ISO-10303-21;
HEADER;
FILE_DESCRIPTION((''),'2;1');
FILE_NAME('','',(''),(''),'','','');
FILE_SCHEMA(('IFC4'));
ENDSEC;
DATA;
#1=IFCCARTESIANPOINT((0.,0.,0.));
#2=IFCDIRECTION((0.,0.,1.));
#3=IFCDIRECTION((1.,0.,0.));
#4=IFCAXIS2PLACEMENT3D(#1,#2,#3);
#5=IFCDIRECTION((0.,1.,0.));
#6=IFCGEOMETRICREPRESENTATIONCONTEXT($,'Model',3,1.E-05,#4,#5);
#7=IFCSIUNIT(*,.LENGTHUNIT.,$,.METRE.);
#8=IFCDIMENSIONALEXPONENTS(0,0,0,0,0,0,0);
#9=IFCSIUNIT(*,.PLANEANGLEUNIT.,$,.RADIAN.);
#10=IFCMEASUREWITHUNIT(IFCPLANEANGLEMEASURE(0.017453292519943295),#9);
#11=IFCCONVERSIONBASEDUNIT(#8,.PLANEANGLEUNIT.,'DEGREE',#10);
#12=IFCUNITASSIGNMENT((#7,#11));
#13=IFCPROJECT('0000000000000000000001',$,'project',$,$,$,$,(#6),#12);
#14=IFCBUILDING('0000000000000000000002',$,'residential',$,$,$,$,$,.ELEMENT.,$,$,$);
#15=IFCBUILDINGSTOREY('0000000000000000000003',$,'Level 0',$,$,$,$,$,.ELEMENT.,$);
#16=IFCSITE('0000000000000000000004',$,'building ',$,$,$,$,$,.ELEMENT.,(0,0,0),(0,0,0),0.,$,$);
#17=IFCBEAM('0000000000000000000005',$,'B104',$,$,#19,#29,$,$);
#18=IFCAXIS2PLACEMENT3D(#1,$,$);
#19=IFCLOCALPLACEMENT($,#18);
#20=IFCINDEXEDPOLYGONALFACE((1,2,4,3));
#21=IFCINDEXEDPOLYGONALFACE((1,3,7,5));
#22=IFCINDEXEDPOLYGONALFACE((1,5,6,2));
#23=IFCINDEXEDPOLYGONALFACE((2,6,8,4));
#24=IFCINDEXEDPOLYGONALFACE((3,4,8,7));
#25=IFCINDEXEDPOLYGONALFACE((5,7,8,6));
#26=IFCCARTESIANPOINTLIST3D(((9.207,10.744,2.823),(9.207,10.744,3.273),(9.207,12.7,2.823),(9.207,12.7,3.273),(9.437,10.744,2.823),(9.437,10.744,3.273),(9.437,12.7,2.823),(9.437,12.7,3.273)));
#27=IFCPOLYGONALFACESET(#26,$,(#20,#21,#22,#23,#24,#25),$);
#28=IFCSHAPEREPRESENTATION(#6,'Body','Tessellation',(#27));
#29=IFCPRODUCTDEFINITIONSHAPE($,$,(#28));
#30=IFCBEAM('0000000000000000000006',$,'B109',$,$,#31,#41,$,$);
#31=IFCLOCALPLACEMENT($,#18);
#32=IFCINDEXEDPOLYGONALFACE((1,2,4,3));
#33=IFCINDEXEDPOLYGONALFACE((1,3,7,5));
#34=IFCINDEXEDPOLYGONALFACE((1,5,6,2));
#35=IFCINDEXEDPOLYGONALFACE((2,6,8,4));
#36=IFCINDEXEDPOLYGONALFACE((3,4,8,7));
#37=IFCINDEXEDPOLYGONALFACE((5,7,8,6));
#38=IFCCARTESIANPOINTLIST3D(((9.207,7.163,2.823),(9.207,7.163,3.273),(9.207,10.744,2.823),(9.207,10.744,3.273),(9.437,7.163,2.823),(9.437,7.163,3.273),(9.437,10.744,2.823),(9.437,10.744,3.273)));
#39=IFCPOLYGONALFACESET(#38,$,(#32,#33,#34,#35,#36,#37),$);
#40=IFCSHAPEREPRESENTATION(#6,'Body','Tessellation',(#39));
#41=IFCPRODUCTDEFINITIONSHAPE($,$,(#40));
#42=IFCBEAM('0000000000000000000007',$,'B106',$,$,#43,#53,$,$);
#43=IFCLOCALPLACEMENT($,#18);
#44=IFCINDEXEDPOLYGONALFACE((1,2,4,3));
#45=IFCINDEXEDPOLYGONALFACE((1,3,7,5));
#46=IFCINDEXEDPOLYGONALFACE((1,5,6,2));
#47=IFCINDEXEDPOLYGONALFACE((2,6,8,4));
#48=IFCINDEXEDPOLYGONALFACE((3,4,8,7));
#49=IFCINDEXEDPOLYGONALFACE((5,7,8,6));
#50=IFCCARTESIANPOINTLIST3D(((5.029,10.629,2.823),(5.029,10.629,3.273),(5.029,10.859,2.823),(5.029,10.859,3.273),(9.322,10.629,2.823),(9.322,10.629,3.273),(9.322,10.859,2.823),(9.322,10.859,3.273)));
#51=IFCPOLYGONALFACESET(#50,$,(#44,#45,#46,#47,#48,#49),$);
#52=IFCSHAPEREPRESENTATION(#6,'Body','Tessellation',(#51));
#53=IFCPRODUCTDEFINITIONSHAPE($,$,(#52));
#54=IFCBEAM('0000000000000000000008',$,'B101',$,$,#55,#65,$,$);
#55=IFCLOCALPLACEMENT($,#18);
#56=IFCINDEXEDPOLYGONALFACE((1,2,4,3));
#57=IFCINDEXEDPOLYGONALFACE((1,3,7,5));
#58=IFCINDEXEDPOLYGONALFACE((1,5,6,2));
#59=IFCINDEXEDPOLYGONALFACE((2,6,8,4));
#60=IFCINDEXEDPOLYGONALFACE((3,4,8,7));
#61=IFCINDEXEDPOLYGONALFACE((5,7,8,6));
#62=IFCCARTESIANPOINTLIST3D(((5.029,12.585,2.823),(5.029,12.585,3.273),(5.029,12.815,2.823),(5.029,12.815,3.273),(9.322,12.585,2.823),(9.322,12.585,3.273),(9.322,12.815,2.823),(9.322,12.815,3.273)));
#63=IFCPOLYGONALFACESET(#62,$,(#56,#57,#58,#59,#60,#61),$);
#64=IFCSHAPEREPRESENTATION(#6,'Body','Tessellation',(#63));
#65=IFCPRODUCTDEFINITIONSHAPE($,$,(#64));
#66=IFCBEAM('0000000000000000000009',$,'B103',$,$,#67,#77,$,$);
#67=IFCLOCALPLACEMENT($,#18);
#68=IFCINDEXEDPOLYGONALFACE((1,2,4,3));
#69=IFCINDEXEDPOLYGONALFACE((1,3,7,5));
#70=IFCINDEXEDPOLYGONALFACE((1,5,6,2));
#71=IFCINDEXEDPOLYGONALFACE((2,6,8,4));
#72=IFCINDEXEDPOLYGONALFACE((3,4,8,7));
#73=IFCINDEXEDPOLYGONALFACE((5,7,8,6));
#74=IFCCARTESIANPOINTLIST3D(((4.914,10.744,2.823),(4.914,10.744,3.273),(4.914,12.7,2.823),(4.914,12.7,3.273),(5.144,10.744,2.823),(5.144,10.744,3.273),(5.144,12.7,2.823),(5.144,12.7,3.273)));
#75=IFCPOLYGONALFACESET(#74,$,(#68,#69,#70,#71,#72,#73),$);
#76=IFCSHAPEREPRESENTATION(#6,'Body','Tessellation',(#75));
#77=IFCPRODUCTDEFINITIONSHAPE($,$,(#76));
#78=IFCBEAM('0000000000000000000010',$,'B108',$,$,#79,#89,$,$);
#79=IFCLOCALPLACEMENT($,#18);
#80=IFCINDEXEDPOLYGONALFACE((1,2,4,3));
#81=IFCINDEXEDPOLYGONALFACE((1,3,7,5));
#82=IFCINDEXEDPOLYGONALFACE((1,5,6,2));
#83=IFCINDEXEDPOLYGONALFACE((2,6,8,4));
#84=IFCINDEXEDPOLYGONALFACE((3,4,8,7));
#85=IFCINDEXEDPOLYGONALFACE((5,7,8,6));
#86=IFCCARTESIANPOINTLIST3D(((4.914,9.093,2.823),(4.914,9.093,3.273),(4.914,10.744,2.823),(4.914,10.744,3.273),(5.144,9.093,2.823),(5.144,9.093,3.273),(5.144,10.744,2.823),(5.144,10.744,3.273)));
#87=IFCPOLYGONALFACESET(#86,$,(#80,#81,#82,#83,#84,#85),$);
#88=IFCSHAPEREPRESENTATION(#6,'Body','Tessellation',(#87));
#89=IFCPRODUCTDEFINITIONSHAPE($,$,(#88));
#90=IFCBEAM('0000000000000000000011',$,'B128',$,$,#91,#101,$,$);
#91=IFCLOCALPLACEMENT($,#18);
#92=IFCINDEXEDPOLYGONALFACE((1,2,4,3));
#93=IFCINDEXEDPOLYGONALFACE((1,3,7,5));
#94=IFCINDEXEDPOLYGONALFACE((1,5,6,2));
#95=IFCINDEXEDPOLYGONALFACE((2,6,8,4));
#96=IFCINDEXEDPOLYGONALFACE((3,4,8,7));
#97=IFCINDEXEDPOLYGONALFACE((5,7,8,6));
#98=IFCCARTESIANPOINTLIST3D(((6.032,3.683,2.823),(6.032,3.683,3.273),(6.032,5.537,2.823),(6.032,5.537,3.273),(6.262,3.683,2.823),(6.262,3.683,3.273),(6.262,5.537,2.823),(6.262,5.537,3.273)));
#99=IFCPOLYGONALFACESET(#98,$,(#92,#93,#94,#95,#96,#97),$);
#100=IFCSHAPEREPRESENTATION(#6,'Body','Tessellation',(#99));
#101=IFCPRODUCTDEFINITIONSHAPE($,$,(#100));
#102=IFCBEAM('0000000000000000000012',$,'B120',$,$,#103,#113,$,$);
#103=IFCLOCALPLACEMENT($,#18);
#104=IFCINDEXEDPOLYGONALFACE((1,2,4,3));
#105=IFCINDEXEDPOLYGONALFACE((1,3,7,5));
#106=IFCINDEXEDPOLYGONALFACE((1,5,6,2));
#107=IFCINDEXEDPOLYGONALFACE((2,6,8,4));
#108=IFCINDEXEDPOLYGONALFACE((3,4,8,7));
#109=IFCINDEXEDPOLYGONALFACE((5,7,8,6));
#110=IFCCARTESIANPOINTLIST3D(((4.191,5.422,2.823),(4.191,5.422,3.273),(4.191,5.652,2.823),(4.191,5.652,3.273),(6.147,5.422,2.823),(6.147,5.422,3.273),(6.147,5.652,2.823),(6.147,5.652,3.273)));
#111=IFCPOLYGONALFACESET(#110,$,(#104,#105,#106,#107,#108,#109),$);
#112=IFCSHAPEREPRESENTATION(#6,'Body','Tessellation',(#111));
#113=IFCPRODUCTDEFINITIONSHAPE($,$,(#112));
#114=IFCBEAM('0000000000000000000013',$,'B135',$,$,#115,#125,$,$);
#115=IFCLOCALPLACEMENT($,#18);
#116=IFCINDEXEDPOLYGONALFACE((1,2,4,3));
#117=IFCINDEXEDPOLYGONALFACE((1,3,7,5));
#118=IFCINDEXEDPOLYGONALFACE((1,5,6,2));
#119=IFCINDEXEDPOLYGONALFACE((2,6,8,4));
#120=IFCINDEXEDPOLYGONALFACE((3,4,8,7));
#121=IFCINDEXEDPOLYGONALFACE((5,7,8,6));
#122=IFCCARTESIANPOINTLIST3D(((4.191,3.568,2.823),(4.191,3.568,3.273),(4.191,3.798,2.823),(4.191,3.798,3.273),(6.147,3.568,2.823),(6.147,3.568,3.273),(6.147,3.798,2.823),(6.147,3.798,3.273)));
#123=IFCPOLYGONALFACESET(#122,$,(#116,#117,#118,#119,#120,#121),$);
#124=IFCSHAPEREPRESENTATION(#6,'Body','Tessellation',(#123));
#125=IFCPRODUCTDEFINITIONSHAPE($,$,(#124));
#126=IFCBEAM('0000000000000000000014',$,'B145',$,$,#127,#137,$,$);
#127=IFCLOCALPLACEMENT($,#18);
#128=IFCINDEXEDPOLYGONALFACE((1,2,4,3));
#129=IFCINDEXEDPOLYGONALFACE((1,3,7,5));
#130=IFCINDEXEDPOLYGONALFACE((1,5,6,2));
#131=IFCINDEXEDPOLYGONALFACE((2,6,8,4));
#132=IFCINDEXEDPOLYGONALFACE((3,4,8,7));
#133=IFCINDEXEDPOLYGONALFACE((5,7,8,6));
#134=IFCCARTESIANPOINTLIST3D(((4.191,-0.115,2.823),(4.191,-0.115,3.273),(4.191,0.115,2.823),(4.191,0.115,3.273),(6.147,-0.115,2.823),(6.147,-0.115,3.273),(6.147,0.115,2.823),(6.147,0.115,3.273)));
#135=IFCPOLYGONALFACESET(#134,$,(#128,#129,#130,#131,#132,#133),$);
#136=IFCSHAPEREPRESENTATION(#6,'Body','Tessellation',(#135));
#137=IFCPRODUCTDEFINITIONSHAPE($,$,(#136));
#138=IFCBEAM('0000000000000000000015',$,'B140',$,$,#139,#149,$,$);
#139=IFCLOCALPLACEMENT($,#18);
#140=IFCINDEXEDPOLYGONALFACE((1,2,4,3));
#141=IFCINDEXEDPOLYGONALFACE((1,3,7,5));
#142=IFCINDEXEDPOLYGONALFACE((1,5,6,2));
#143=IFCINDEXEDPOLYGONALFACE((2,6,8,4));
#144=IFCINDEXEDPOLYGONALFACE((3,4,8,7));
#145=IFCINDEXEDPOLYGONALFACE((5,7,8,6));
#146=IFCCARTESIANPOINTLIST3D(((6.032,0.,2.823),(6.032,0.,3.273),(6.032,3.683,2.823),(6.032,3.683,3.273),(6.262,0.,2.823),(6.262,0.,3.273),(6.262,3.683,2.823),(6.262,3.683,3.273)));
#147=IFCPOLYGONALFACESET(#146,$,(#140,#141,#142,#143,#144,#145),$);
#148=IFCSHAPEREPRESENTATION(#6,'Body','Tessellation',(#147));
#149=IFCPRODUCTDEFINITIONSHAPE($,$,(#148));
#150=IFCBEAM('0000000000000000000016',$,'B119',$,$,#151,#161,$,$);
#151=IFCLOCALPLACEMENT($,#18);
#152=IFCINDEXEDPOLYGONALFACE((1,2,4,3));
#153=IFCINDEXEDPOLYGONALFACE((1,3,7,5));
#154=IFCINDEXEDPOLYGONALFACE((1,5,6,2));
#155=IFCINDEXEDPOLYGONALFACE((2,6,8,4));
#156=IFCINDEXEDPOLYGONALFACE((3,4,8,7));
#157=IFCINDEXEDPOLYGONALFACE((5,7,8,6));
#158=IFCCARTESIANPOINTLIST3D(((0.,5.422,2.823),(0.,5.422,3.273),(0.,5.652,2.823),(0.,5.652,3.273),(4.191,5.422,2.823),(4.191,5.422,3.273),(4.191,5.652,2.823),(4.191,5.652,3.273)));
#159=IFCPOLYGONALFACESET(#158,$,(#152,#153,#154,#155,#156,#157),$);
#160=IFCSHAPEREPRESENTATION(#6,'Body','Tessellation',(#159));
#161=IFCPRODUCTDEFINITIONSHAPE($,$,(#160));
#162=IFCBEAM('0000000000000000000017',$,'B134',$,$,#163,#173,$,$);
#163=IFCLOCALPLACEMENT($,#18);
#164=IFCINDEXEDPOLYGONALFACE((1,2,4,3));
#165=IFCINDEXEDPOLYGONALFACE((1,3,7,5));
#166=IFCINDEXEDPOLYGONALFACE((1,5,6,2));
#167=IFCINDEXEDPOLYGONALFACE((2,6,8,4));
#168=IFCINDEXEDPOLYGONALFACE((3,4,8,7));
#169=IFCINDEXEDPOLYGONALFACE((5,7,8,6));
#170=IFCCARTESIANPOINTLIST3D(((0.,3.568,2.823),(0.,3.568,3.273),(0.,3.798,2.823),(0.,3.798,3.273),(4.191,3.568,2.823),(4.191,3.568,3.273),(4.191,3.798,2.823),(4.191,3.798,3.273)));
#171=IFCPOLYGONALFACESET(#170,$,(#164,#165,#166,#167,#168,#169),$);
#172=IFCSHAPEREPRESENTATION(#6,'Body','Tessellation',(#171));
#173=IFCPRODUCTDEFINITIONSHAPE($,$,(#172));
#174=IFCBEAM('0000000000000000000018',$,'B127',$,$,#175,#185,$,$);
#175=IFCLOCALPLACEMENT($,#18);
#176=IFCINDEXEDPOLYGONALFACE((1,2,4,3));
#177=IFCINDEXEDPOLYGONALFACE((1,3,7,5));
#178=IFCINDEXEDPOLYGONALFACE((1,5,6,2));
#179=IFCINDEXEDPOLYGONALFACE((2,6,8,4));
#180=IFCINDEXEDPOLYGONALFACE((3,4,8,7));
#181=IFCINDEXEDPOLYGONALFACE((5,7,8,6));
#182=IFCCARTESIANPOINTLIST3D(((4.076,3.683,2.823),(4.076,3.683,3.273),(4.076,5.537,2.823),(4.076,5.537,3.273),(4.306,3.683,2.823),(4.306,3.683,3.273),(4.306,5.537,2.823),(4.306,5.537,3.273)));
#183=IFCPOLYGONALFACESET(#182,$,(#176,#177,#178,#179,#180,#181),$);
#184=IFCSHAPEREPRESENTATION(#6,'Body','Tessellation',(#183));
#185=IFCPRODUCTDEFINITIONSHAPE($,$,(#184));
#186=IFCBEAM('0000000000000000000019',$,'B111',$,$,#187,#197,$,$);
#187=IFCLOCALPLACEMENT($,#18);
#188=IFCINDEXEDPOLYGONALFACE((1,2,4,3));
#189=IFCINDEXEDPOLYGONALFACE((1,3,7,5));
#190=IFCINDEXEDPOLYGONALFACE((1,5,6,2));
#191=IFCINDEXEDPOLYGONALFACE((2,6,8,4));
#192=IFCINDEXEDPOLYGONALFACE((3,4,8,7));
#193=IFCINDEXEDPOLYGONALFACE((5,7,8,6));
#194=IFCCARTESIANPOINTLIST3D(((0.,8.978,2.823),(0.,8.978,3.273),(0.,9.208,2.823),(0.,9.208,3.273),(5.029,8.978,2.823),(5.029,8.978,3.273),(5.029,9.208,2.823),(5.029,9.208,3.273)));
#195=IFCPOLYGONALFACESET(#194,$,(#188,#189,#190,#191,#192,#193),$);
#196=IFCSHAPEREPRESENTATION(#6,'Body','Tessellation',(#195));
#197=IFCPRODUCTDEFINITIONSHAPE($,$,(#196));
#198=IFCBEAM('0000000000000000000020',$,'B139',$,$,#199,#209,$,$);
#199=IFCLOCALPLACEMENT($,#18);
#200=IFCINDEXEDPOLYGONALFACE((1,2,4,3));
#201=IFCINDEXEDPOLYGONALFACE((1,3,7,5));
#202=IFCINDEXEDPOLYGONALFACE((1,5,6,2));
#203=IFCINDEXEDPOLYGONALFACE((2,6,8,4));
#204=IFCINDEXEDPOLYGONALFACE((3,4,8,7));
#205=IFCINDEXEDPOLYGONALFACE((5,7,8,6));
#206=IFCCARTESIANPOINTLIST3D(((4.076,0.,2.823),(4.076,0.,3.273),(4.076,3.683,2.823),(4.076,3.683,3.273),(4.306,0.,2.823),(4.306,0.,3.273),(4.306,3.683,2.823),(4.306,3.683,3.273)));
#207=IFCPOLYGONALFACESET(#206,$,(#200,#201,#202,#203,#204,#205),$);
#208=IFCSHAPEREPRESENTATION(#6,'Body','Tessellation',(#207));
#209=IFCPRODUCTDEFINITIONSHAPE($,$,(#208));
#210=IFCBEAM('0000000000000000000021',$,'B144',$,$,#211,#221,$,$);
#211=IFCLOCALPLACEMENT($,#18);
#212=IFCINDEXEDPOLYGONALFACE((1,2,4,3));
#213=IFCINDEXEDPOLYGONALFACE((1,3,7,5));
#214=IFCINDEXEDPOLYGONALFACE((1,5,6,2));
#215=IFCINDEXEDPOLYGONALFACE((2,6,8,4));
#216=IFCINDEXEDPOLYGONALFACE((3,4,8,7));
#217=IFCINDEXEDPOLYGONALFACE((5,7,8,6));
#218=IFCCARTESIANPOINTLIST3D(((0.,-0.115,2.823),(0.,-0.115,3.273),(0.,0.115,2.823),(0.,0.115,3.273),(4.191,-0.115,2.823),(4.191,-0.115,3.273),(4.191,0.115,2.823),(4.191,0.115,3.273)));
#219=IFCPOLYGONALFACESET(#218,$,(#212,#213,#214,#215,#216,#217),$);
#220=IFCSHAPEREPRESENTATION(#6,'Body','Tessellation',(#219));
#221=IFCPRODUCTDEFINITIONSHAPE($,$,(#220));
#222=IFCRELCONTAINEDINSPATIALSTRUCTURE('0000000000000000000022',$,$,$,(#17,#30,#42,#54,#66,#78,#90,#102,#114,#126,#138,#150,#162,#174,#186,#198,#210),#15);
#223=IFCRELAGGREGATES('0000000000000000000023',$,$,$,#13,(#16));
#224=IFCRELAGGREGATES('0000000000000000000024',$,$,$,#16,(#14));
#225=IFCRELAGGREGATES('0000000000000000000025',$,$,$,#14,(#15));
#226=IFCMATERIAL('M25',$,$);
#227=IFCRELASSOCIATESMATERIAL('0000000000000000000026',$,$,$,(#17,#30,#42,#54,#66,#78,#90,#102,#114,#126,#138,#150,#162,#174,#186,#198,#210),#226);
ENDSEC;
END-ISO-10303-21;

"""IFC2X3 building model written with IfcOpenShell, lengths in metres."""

from ifc_helpers import new_model, entity, si_unit, converted_unit, direction, frame, frame_2d, origin_with_axes, place, context, project, spatial, rectangle, extrude, material, element, save


model = new_model("IFC2X3")

# Units and contexts
model_context = context("Model", 3, precision=1e-05, world=origin_with_axes(), true_north=direction((0.0, 1.0, 0.0)))
ifc_project = project(units=[si_unit("LENGTHUNIT", "METRE"), converted_unit("PLANEANGLEUNIT", "DEGREE", entity("IfcPlaneAngleMeasure", 0.017453292519943295), si_unit("PLANEANGLEUNIT", "RADIAN"), dimensions=[0, 0, 0, 0, 0, 0, 0])], contexts=[model_context])

# Site, building, storey
site = spatial("IfcSite", under=ifc_project, Name="building ", CompositionType="ELEMENT", RefLatitude=(0, 0, 0), RefLongitude=(0, 0, 0), RefElevation=0.0)
building = spatial("IfcBuilding", under=site, Name="residential", CompositionType="ELEMENT")
storey = spatial("IfcBuildingStorey", under=building, Name="Level 0", CompositionType="ELEMENT")

# Beams
ifc_material = material(Name="M25")
placement = place(None, origin_with_axes())
element("IfcBeam", 1, at=placement, inside=storey, material=ifc_material, Name="B104", context=model_context, shape_type="SweptSolid", body=[
    extrude(rectangle(XDim=0.23, YDim=0.45, at=frame_2d((0.0, 0.0), x_axis=(0.0, 1.0, 0.0))), frame((9.322, 10.744, 3.048), z_axis=(0.0, 1.0, 0.0), x_axis=(0.0, 0.0, -1.0)), (0.0, 0.0, 1.0), 1.956),
])
element("IfcBeam", 2, at=placement, inside=storey, material=ifc_material, Name="B109", context=model_context, shape_type="SweptSolid", body=[
    extrude(rectangle(XDim=0.23, YDim=0.45, at=frame_2d((0.0, 0.0), x_axis=(0.0, 1.0, 0.0))), frame((9.322, 7.163, 3.048), z_axis=(0.0, 1.0, 0.0), x_axis=(0.0, 0.0, -1.0)), (0.0, 0.0, 1.0), 3.581),
])
element("IfcBeam", 3, at=placement, inside=storey, material=ifc_material, Name="B106", context=model_context, shape_type="SweptSolid", body=[
    extrude(rectangle(XDim=0.23, YDim=0.45, at=frame_2d((0.0, 0.0), x_axis=(0.0, 1.0, 0.0))), frame((5.029, 10.744, 3.048), z_axis=(1.0, 0.0, 0.0), x_axis=(0.0, 0.0, -1.0)), (0.0, 0.0, 1.0), 4.293),
])
element("IfcBeam", 4, at=placement, inside=storey, material=ifc_material, Name="B101", context=model_context, shape_type="SweptSolid", body=[
    extrude(rectangle(XDim=0.23, YDim=0.45, at=frame_2d((0.0, 0.0), x_axis=(0.0, 1.0, 0.0))), frame((5.029, 12.7, 3.048), z_axis=(1.0, 0.0, 0.0), x_axis=(0.0, 0.0, -1.0)), (0.0, 0.0, 1.0), 4.293),
])
element("IfcBeam", 5, at=placement, inside=storey, material=ifc_material, Name="B103", context=model_context, shape_type="SweptSolid", body=[
    extrude(rectangle(XDim=0.23, YDim=0.45, at=frame_2d((0.0, 0.0), x_axis=(0.0, 1.0, 0.0))), frame((5.029, 10.744, 3.048), z_axis=(0.0, 1.0, 0.0), x_axis=(0.0, 0.0, -1.0)), (0.0, 0.0, 1.0), 1.956),
])
element("IfcBeam", 6, at=placement, inside=storey, material=ifc_material, Name="B108", context=model_context, shape_type="SweptSolid", body=[
    extrude(rectangle(XDim=0.23, YDim=0.45, at=frame_2d((0.0, 0.0), x_axis=(0.0, 1.0, 0.0))), frame((5.029, 9.093, 3.048), z_axis=(0.0, 1.0, 0.0), x_axis=(0.0, 0.0, -1.0)), (0.0, 0.0, 1.0), 1.651),
])
element("IfcBeam", 7, at=placement, inside=storey, material=ifc_material, Name="B128", context=model_context, shape_type="SweptSolid", body=[
    extrude(rectangle(XDim=0.23, YDim=0.45, at=frame_2d((0.0, 0.0), x_axis=(0.0, 1.0, 0.0))), frame((6.147, 3.683, 3.048), z_axis=(0.0, 1.0, 0.0), x_axis=(0.0, 0.0, -1.0)), (0.0, 0.0, 1.0), 1.854),
])
element("IfcBeam", 8, at=placement, inside=storey, material=ifc_material, Name="B120", context=model_context, shape_type="SweptSolid", body=[
    extrude(rectangle(XDim=0.23, YDim=0.45, at=frame_2d((0.0, 0.0), x_axis=(0.0, 1.0, 0.0))), frame((4.191, 5.537, 3.048), z_axis=(1.0, 0.0, 0.0), x_axis=(0.0, 0.0, -1.0)), (0.0, 0.0, 1.0), 1.956),
])
element("IfcBeam", 9, at=placement, inside=storey, material=ifc_material, Name="B135", context=model_context, shape_type="SweptSolid", body=[
    extrude(rectangle(XDim=0.23, YDim=0.45, at=frame_2d((0.0, 0.0), x_axis=(0.0, 1.0, 0.0))), frame((4.191, 3.683, 3.048), z_axis=(1.0, 0.0, 0.0), x_axis=(0.0, 0.0, -1.0)), (0.0, 0.0, 1.0), 1.956),
])
element("IfcBeam", 10, at=placement, inside=storey, material=ifc_material, Name="B145", context=model_context, shape_type="SweptSolid", body=[
    extrude(rectangle(XDim=0.23, YDim=0.45, at=frame_2d((0.0, 0.0), x_axis=(0.0, 1.0, 0.0))), frame((4.191, 0.0, 3.048), z_axis=(1.0, 0.0, 0.0), x_axis=(0.0, 0.0, -1.0)), (0.0, 0.0, 1.0), 1.956),
])
element("IfcBeam", 11, at=placement, inside=storey, material=ifc_material, Name="B140", context=model_context, shape_type="SweptSolid", body=[
    extrude(rectangle(XDim=0.23, YDim=0.45, at=frame_2d((0.0, 0.0), x_axis=(0.0, 1.0, 0.0))), frame((6.147, 0.0, 3.048), z_axis=(0.0, 1.0, 0.0), x_axis=(0.0, 0.0, -1.0)), (0.0, 0.0, 1.0), 3.683),
])
element("IfcBeam", 12, at=placement, inside=storey, material=ifc_material, Name="B119", context=model_context, shape_type="SweptSolid", body=[
    extrude(rectangle(XDim=0.23, YDim=0.45, at=frame_2d((0.0, 0.0), x_axis=(0.0, 1.0, 0.0))), frame((0.0, 5.537, 3.048), z_axis=(1.0, 0.0, 0.0), x_axis=(0.0, 0.0, -1.0)), (0.0, 0.0, 1.0), 4.191),
])
element("IfcBeam", 13, at=placement, inside=storey, material=ifc_material, Name="B134", context=model_context, shape_type="SweptSolid", body=[
    extrude(rectangle(XDim=0.23, YDim=0.45, at=frame_2d((0.0, 0.0), x_axis=(0.0, 1.0, 0.0))), frame((0.0, 3.683, 3.048), z_axis=(1.0, 0.0, 0.0), x_axis=(0.0, 0.0, -1.0)), (0.0, 0.0, 1.0), 4.191),
])
element("IfcBeam", 14, at=placement, inside=storey, material=ifc_material, Name="B127", context=model_context, shape_type="SweptSolid", body=[
    extrude(rectangle(XDim=0.23, YDim=0.45, at=frame_2d((0.0, 0.0), x_axis=(0.0, 1.0, 0.0))), frame((4.191, 3.683, 3.048), z_axis=(0.0, 1.0, 0.0), x_axis=(0.0, 0.0, -1.0)), (0.0, 0.0, 1.0), 1.854),
])
element("IfcBeam", 15, at=placement, inside=storey, material=ifc_material, Name="B111", context=model_context, shape_type="SweptSolid", body=[
    extrude(rectangle(XDim=0.23, YDim=0.45, at=frame_2d((0.0, 0.0), x_axis=(0.0, 1.0, 0.0))), frame((0.0, 9.093, 3.048), z_axis=(1.0, 0.0, 0.0), x_axis=(0.0, 0.0, -1.0)), (0.0, 0.0, 1.0), 5.029),
])
element("IfcBeam", 16, at=placement, inside=storey, material=ifc_material, Name="B139", context=model_context, shape_type="SweptSolid", body=[
    extrude(rectangle(XDim=0.23, YDim=0.45, at=frame_2d((0.0, 0.0), x_axis=(0.0, 1.0, 0.0))), frame((4.191, 0.0, 3.048), z_axis=(0.0, 1.0, 0.0), x_axis=(0.0, 0.0, -1.0)), (0.0, 0.0, 1.0), 3.683),
])
element("IfcBeam", 17, at=placement, inside=storey, material=ifc_material, Name="B144", context=model_context, shape_type="SweptSolid", body=[
    extrude(rectangle(XDim=0.23, YDim=0.45, at=frame_2d((0.0, 0.0), x_axis=(0.0, 1.0, 0.0))), frame((0.0, 0.0, 3.048), z_axis=(1.0, 0.0, 0.0), x_axis=(0.0, 0.0, -1.0)), (0.0, 0.0, 1.0), 4.191),
])

save(model, "model.ifc")
